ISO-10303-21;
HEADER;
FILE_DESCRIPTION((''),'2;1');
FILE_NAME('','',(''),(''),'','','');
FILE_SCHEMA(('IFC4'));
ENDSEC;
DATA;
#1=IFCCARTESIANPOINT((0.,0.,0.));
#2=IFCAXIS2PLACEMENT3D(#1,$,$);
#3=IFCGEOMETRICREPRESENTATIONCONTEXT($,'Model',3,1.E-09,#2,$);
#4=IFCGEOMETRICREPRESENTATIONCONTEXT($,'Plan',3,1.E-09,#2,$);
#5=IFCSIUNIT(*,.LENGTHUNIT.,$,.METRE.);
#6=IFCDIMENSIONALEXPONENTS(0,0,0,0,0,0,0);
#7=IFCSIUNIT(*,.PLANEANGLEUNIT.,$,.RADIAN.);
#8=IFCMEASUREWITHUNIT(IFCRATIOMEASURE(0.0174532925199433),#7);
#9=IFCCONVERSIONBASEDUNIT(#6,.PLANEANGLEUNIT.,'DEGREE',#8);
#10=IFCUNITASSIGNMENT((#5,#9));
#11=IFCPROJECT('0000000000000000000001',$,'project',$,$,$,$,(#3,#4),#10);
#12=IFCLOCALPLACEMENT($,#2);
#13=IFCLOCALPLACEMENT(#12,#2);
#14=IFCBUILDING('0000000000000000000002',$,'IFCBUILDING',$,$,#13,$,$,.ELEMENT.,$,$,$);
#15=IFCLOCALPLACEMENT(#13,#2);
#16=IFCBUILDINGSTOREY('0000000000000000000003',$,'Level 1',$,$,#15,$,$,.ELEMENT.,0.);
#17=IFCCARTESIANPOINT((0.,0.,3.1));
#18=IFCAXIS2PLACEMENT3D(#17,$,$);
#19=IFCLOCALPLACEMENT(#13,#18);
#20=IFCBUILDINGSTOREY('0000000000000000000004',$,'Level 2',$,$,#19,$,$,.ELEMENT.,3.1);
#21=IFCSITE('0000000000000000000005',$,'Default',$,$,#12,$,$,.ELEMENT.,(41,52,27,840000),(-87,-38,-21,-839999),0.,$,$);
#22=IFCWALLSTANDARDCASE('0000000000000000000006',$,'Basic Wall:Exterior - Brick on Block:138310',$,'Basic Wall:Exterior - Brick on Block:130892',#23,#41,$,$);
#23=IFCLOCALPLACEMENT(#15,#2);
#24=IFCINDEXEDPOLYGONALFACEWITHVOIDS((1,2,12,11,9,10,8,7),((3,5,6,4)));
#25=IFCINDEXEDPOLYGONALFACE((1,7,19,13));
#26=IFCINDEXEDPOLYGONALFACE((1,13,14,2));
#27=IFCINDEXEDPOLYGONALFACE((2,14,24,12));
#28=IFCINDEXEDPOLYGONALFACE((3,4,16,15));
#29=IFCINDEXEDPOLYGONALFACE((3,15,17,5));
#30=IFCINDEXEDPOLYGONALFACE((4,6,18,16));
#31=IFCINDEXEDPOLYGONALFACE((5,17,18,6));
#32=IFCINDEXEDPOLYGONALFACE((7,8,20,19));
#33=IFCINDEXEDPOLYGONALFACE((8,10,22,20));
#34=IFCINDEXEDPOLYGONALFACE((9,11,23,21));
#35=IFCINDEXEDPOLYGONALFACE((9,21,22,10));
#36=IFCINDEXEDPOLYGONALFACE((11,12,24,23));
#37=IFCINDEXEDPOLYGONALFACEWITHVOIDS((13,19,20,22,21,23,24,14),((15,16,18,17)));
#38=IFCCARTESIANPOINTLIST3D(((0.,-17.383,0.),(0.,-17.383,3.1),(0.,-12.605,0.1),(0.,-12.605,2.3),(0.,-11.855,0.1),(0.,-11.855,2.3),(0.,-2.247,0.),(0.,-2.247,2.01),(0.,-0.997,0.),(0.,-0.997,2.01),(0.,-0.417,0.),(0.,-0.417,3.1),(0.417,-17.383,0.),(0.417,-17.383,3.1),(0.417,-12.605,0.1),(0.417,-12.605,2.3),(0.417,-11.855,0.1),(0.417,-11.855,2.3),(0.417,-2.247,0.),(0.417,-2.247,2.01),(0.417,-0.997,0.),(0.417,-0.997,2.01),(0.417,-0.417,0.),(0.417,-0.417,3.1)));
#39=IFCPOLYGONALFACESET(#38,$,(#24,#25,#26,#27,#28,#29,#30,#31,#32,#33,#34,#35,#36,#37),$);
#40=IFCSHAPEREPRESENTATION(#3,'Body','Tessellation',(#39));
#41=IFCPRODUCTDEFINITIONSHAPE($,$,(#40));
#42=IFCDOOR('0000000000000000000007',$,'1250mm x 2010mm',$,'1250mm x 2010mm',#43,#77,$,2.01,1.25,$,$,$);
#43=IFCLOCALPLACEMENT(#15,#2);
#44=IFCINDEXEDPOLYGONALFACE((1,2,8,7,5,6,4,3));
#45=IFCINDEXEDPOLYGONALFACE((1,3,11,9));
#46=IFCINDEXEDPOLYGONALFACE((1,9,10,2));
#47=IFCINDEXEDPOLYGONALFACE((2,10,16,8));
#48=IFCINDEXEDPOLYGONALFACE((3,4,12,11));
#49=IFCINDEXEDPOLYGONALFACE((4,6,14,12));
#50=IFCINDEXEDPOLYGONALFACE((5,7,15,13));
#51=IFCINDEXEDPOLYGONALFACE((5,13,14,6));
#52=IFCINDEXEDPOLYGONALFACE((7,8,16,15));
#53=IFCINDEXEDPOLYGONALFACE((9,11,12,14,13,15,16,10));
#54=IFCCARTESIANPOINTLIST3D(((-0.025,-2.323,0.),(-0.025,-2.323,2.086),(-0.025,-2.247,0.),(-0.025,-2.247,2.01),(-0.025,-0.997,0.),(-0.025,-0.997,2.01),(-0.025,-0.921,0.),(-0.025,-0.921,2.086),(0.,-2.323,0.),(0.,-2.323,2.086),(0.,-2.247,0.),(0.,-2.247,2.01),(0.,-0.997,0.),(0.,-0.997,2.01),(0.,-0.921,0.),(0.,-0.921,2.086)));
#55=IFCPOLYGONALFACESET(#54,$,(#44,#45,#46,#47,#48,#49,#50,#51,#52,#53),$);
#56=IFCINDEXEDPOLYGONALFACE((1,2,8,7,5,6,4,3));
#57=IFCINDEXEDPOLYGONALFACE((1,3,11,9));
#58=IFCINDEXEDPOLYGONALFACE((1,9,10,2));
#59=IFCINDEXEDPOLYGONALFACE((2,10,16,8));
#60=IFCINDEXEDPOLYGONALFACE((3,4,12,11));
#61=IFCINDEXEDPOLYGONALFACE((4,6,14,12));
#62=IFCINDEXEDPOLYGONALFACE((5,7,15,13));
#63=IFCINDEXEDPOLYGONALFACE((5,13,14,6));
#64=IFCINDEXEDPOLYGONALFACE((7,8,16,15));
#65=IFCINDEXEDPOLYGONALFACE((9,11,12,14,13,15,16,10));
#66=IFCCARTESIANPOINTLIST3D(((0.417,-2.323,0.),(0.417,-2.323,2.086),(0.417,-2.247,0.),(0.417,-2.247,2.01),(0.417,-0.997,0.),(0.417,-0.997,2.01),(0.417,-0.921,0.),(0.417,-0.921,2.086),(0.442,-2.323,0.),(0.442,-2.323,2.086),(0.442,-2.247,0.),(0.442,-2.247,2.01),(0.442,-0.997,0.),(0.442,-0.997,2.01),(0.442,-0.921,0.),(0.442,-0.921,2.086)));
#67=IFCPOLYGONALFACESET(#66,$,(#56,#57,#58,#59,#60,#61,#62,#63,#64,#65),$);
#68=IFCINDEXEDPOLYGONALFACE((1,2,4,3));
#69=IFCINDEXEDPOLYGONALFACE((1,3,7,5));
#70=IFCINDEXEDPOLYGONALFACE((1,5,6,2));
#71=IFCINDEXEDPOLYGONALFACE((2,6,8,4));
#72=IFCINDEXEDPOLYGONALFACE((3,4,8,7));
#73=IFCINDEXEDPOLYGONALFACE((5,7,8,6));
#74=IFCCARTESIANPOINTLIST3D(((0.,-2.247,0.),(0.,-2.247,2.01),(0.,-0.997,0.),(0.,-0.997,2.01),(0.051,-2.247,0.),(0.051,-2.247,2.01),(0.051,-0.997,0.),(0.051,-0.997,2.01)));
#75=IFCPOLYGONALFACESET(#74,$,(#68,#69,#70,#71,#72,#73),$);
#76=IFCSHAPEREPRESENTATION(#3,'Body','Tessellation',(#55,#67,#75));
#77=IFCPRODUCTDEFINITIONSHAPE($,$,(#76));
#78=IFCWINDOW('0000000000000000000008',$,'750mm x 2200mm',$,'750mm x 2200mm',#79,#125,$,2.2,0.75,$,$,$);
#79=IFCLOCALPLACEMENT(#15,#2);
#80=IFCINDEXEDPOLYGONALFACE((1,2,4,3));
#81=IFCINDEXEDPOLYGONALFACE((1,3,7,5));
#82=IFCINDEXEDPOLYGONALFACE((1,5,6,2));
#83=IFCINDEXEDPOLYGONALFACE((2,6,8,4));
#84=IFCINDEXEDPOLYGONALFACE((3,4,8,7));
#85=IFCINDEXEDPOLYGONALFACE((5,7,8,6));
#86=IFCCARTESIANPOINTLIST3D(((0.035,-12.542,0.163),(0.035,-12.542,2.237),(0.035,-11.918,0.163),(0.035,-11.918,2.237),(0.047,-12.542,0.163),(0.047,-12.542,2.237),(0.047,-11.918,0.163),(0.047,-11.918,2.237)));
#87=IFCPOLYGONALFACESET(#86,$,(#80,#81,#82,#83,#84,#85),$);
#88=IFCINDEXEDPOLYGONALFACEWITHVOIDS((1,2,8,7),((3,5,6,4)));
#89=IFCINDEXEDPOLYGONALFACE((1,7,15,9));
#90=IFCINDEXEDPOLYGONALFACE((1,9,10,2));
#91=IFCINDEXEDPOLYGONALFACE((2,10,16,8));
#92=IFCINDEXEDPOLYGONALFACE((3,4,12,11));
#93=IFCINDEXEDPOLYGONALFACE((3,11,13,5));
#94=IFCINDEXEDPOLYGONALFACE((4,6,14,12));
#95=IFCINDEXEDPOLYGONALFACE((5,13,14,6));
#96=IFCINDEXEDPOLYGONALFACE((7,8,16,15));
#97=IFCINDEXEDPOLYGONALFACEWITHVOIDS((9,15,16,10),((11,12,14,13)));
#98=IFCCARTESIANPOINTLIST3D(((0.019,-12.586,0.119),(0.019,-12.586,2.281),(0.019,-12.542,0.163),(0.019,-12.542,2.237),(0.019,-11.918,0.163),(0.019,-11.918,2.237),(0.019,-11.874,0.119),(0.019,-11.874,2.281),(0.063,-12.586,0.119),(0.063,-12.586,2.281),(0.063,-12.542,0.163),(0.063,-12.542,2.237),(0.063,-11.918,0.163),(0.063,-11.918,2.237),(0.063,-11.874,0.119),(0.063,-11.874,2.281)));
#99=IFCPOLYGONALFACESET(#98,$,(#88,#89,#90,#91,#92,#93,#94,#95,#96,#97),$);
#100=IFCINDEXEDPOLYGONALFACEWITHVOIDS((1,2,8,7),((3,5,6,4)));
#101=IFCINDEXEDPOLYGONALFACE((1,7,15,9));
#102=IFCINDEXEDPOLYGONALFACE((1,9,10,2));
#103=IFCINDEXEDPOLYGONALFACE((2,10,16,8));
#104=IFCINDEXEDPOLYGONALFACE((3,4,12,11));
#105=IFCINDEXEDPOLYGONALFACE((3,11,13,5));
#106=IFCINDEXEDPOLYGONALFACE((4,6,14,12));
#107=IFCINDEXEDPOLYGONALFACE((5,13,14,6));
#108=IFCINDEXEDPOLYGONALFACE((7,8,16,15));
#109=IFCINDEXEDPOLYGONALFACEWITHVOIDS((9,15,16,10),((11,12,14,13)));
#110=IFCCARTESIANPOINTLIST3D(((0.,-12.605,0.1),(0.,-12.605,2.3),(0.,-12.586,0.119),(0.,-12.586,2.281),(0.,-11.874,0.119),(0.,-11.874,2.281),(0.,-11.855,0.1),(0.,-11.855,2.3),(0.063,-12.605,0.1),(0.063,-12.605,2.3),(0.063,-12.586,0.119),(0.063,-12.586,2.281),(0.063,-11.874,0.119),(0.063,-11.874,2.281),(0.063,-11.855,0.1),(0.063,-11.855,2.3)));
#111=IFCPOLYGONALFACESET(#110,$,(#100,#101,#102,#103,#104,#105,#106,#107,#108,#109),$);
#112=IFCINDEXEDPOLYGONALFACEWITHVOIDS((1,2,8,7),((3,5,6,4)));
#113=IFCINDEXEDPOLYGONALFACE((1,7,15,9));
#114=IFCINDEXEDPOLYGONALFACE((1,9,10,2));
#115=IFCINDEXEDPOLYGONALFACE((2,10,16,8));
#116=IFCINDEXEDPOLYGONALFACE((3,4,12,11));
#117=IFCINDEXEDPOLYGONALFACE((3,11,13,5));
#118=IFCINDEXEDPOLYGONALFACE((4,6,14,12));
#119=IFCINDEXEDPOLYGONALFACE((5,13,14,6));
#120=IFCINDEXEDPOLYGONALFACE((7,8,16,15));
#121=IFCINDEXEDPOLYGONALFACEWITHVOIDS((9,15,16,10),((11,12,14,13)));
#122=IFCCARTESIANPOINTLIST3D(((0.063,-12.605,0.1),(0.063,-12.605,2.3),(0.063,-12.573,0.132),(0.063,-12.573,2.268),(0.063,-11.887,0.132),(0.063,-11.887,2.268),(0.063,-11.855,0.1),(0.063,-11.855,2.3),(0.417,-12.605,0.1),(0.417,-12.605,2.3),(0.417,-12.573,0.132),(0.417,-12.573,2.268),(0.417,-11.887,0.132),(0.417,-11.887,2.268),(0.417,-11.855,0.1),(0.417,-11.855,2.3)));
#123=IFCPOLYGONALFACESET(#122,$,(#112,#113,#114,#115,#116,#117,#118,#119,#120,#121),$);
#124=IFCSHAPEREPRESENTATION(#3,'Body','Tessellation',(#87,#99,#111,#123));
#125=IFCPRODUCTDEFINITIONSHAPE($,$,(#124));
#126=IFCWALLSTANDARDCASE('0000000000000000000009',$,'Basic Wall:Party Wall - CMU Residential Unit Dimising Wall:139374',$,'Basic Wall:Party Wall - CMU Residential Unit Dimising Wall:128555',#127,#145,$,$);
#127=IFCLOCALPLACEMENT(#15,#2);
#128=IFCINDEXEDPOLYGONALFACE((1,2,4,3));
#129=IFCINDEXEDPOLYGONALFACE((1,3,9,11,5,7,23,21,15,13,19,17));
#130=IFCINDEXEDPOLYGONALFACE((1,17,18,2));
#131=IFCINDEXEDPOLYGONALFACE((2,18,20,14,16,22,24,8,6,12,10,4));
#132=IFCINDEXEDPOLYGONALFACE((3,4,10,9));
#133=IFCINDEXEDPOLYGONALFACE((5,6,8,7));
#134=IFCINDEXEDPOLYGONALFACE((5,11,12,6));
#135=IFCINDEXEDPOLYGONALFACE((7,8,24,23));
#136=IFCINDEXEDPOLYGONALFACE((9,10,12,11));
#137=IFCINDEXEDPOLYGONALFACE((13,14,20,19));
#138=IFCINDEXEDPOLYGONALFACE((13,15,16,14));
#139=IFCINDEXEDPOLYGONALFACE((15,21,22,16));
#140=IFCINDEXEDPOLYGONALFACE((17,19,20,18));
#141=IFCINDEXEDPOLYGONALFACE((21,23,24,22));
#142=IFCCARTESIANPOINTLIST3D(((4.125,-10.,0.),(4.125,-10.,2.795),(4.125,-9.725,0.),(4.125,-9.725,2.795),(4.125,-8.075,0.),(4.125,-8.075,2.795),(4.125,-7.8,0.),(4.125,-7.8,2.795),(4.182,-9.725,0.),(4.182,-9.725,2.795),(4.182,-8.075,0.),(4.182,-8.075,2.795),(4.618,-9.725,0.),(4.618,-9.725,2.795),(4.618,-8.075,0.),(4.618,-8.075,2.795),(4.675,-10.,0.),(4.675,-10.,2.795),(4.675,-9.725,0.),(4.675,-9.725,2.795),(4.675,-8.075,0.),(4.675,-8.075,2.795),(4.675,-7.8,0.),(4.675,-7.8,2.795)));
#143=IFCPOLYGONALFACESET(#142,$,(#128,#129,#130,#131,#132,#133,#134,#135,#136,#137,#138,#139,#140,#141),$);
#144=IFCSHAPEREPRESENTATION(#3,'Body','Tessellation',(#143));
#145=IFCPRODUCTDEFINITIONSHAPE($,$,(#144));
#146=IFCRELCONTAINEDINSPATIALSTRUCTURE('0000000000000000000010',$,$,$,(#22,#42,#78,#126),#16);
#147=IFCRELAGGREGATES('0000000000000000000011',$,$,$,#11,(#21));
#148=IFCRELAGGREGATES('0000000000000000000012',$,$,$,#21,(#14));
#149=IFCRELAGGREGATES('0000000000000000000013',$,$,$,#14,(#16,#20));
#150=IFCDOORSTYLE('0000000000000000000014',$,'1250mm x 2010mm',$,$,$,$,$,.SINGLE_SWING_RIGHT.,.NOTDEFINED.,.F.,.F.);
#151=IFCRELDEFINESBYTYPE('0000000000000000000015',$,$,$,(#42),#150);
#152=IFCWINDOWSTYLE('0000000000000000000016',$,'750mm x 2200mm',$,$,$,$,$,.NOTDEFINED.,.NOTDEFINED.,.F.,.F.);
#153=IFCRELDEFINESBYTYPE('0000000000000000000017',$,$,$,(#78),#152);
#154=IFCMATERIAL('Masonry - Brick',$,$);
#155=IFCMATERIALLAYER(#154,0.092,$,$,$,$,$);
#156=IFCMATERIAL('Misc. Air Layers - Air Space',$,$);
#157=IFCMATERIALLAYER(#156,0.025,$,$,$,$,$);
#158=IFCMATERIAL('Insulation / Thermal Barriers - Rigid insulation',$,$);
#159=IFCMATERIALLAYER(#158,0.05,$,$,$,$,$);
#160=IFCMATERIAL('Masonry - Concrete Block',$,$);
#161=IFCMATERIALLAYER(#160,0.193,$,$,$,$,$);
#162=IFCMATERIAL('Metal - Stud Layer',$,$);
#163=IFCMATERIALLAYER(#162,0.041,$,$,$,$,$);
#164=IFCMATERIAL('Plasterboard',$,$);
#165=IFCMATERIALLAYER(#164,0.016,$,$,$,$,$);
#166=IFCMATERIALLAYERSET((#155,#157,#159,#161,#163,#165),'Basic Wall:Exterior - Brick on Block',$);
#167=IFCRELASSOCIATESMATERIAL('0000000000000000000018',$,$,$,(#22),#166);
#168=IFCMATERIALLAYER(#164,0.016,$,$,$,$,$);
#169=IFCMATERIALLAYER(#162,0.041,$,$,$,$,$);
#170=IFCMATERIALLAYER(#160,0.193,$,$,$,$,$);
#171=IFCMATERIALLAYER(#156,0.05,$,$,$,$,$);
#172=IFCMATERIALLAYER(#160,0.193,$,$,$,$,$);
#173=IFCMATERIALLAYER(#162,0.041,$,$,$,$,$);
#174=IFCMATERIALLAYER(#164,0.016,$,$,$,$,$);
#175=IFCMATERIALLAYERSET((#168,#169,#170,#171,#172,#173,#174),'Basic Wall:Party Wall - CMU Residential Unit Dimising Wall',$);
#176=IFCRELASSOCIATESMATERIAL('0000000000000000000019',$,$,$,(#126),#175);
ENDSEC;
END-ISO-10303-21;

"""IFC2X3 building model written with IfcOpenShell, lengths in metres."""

from ifc_helpers import new_model, entity, si_unit, converted_unit, frame, frame_2d, origin, origin_2d_with_axis, place, context, project, spatial, polyline, rectangle, outline, extrude, clip, bounded_halfspace, source, transform, mapped, material, layer, layer_set, layer_usage, type_object, type_shapes, element, fill, save


model = new_model("IFC2X3")

# Units and contexts
model_context = context("Model", 3, precision=1e-09, world=origin())
plan_context = context("Plan", 3, precision=1e-09, world=origin())
ifc_project = project(units=[si_unit("LENGTHUNIT", "METRE"), converted_unit("PLANEANGLEUNIT", "DEGREE", entity("IfcRatioMeasure", 0.0174532925199433), si_unit("PLANEANGLEUNIT", "RADIAN"), dimensions=[0, 0, 0, 0, 0, 0, 0])], contexts=[model_context, plan_context])

# Site, building, storey
site_placement = place(None, origin())
site = spatial("IfcSite", under=ifc_project, at=site_placement, Name="Default", CompositionType="ELEMENT", RefLatitude=(41, 52, 27, 840000), RefLongitude=(-87, -38, -21, -839999), RefElevation=0.0)
building_placement = place(site_placement, origin())
building = spatial("IfcBuilding", under=site, at=building_placement, Name="IFCBUILDING", CompositionType="ELEMENT")
storey_1_placement = place(building_placement, origin())
storey_1 = spatial("IfcBuildingStorey", under=building, at=storey_1_placement, Name="Level 1", CompositionType="ELEMENT", Elevation=0.0)

# Shared definitions
ifc_material_1 = material(Name="Masonry - Brick")
ifc_layer_1 = layer(ifc_material_1, 0.092)
ifc_material_2 = material(Name="Misc. Air Layers - Air Space")
ifc_layer_2 = layer(ifc_material_2, 0.025)
ifc_material_3 = material(Name="Insulation / Thermal Barriers - Rigid insulation")
ifc_layer_3 = layer(ifc_material_3, 0.05)
ifc_material_4 = material(Name="Masonry - Concrete Block")
ifc_layer_4 = layer(ifc_material_4, 0.193)
ifc_material_5 = material(Name="Metal - Stud Layer")
ifc_layer_5 = layer(ifc_material_5, 0.041)
ifc_material_6 = material(Name="Plasterboard")
ifc_layer_6 = layer(ifc_material_6, 0.016)
ifc_layer_set_1 = layer_set([ifc_layer_1, ifc_layer_2, ifc_layer_3, ifc_layer_4, ifc_layer_5, ifc_layer_6], Name="Basic Wall:Exterior - Brick on Block")

# Wall, openings, door, window
ifc_layer_usage_1 = layer_usage(ifc_layer_set_1, "AXIS2", "NEGATIVE", 0.2085)
wall_1_placement = place(storey_1_placement, frame((0.2085, -17.383, 0.0), z_axis=(0.0, 0.0, 1.0), x_axis=(0.0, 1.0, 0.0)))
wall_1 = element("IfcWallStandardCase", 1, at=wall_1_placement, inside=storey_1, material=ifc_layer_usage_1, Name="Basic Wall:Exterior - Brick on Block:138310", ObjectType="Basic Wall:Exterior - Brick on Block:130892", context=model_context, shape_type="SweptSolid", body=[
    extrude(rectangle(XDim=16.966, YDim=0.417, at=frame_2d((8.483, 0.0), x_axis=(-1.0, 0.0))), origin(), (0.0, 0.0, 1.0), 3.1),
])
opening_1_placement = place(wall_1_placement, frame((15.136, -0.2085, 0.0)))
opening_1 = element("IfcOpeningElement", 2, at=opening_1_placement, cuts=wall_1, ObjectType="Opening", context=model_context, shape_type="SweptSolid", body=[
    extrude(rectangle(XDim=1.25, YDim=2.01, at=frame_2d((1.005, 0.625), x_axis=(0.0, 1.0))), frame((0.0, 0.0, 0.0), z_axis=(0.0, 1.0, 0.0), x_axis=(0.0, 0.0, 1.0)), (0.0, 0.0, 1.0), 0.417),
])
opening_2_placement = place(wall_1_placement, frame((4.778, -0.2085, 0.1)))
opening_2 = element("IfcOpeningElement", 3, at=opening_2_placement, cuts=wall_1, ObjectType="Opening", context=model_context, shape_type="SweptSolid", body=[
    extrude(rectangle(XDim=2.2, YDim=0.75, at=frame_2d((1.1, 0.375), x_axis=(1.0, 0.0))), frame((0.0, 0.0, 0.0), z_axis=(0.0, 1.0, 0.0), x_axis=(0.0, 0.0, 1.0)), (0.0, 0.0, 1.0), 0.417),
])
door_style_1 = type_object("IfcDoorStyle", Name="1250mm x 2010mm", ConstructionType="NOTDEFINED", OperationType="SINGLE_SWING_RIGHT", ParameterTakesPrecedence=False, Sizeable=False)
shared_shape_1 = source(origin(), model_context, "Body", "SweptSolid", [
    extrude(outline(polyline([(-0.701, -1.062), (0.701, -1.062), (0.701, 1.024), (0.625, 1.024), (0.625, -0.986), (-0.625, -0.986), (-0.625, 1.024), (-0.701, 1.024), (-0.701, -1.062)])), frame((0.625, 0.417, 1.024), z_axis=(0.0, 1.0, 0.0), x_axis=(1.0, 0.0, 0.0)), (0.0, 0.0, 1.0), 0.025),
    extrude(outline(polyline([(-1.062, -0.701), (1.024, -0.701), (1.024, -0.625), (-0.986, -0.625), (-0.986, 0.625), (1.024, 0.625), (1.024, 0.701), (-1.062, 0.701), (-1.062, -0.701)])), frame((0.625, -0.025, 1.024), z_axis=(0.0, 1.0, 0.0), x_axis=(0.0, 0.0, -1.0)), (0.0, 0.0, 1.0), 0.025),
    extrude(rectangle(XDim=0.051, YDim=1.25, at=origin_2d_with_axis()), frame((0.625, 0.3915, 0.0), z_axis=(0.0, 0.0, 1.0), x_axis=(0.0, 1.0, 0.0)), (0.0, 0.0, 1.0), 2.01),
])
type_shapes(door_style_1, [shared_shape_1])
door_1_placement = place(opening_1_placement, origin())
door_1 = element("IfcDoor", 4, at=door_1_placement, inside=storey_1, type_object=door_style_1, Name="1250mm x 2010mm", ObjectType="1250mm x 2010mm", OverallHeight=2.01, OverallWidth=1.25, context=model_context, shape_type="MappedRepresentation", body=[
    mapped(shared_shape_1, transform((0.0, 0.0, 0.0), scale=1.0)),
])
fill(opening_1, door_1)
window_style_1 = type_object("IfcWindowStyle", Name="750mm x 2200mm", ConstructionType="NOTDEFINED", OperationType="NOTDEFINED", ParameterTakesPrecedence=False, Sizeable=False)
shared_shape_2 = source(origin(), model_context, "Body", "SweptSolid", [
    extrude(rectangle(XDim=0.012, YDim=0.624, at=origin_2d_with_axis()), frame((0.375, 0.376, 0.063), z_axis=(0.0, 0.0, 1.0), x_axis=(0.0, -1.0, 0.0)), (0.0, 0.0, 1.0), 2.074),
    extrude(outline(polyline([(-0.356, -1.081), (0.356, -1.081), (0.356, 1.081), (-0.356, 1.081), (-0.356, -1.081)]), holes=[polyline([(-0.312, -1.037), (-0.312, 1.037), (0.312, 1.037), (0.312, -1.037), (-0.312, -1.037)])]), frame((0.375, 0.354, 1.1), z_axis=(0.0, 1.0, 0.0), x_axis=(1.0, 0.0, 0.0)), (0.0, 0.0, 1.0), 0.044),
    extrude(outline(polyline([(-0.375, -1.1), (0.375, -1.1), (0.375, 1.1), (-0.375, 1.1), (-0.375, -1.1)]), holes=[polyline([(-0.356, -1.081), (-0.356, 1.081), (0.356, 1.081), (0.356, -1.081), (-0.356, -1.081)])]), frame((0.375, 0.354, 1.1), z_axis=(0.0, 1.0, 0.0), x_axis=(1.0, 0.0, 0.0)), (0.0, 0.0, 1.0), 0.063),
    extrude(outline(polyline([(-0.375, -1.1), (0.375, -1.1), (0.375, 1.1), (-0.375, 1.1), (-0.375, -1.1)]), holes=[polyline([(-0.343, -1.068), (-0.343, 1.068), (0.343, 1.068), (0.343, -1.068), (-0.343, -1.068)])]), frame((0.375, 0.0, 1.1), z_axis=(0.0, 1.0, 0.0), x_axis=(1.0, 0.0, 0.0)), (0.0, 0.0, 1.0), 0.354),
])
type_shapes(window_style_1, [shared_shape_2])
window_1_placement = place(opening_2_placement, origin())
window_1 = element("IfcWindow", 5, at=window_1_placement, inside=storey_1, type_object=window_style_1, Name="750mm x 2200mm", ObjectType="750mm x 2200mm", OverallHeight=2.2, OverallWidth=0.75, context=model_context, shape_type="MappedRepresentation", body=[
    mapped(shared_shape_2, transform((0.0, 0.0, 0.0), scale=1.0)),
])
fill(opening_2, window_1)

# Wall
ifc_layer_7 = layer(ifc_material_6, 0.016)
ifc_layer_8 = layer(ifc_material_5, 0.041)
ifc_layer_9 = layer(ifc_material_4, 0.193)
ifc_layer_10 = layer(ifc_material_2, 0.05)
ifc_layer_11 = layer(ifc_material_4, 0.193)
ifc_layer_12 = layer(ifc_material_5, 0.041)
ifc_layer_13 = layer(ifc_material_6, 0.016)
ifc_layer_set_2 = layer_set([ifc_layer_7, ifc_layer_8, ifc_layer_9, ifc_layer_10, ifc_layer_11, ifc_layer_12, ifc_layer_13], Name="Basic Wall:Party Wall - CMU Residential Unit Dimising Wall")
ifc_layer_usage_2 = layer_usage(ifc_layer_set_2, "AXIS2", "NEGATIVE", 0.275)
wall_2_placement = place(storey_1_placement, frame((4.4, -10.0, 0.0), z_axis=(0.0, 0.0, 1.0), x_axis=(0.0, 1.0, 0.0)))
element("IfcWallStandardCase", 6, at=wall_2_placement, inside=storey_1, material=ifc_layer_usage_2, Name="Basic Wall:Party Wall - CMU Residential Unit Dimising Wall:139374", ObjectType="Basic Wall:Party Wall - CMU Residential Unit Dimising Wall:128555", context=model_context, shape_type="Clipping", body=[
    clip(clip(extrude(rectangle(XDim=2.2, YDim=0.55, at=frame_2d((1.1, 0.0), x_axis=(-1.0, 0.0))), origin(), (0.0, 0.0, 1.0), 2.795), bounded_halfspace(frame((1.925, 0.218, 0.0), z_axis=(0.0, -1.0, 0.0), x_axis=(1.0, 0.0, 0.0)), True, frame((1.925, 0.218, 0.0), z_axis=(0.0, -1.0, 0.0), x_axis=(1.0, 0.0, 0.0)), polyline([(0.0, 0.0), (0.0, 2.795), (-1.65, 2.795), (-1.65, 0.0), (0.0, 0.0)]))), bounded_halfspace(frame((0.275, -0.218, 0.0), z_axis=(0.0, 1.0, 0.0), x_axis=(-1.0, 0.0, 0.0)), True, frame((0.275, -0.218, 0.0), z_axis=(0.0, 1.0, 0.0), x_axis=(-1.0, 0.0, 0.0)), polyline([(0.0, 0.0), (0.0, 2.795), (-1.65, 2.795), (-1.65, 0.0), (0.0, 0.0)]))),
])

# Shared definitions
storey_2_placement = place(building_placement, frame((0.0, 0.0, 3.1)))
storey_2 = spatial("IfcBuildingStorey", under=building, at=storey_2_placement, Name="Level 2", CompositionType="ELEMENT", Elevation=3.1)

save(model, "model.ifc")
